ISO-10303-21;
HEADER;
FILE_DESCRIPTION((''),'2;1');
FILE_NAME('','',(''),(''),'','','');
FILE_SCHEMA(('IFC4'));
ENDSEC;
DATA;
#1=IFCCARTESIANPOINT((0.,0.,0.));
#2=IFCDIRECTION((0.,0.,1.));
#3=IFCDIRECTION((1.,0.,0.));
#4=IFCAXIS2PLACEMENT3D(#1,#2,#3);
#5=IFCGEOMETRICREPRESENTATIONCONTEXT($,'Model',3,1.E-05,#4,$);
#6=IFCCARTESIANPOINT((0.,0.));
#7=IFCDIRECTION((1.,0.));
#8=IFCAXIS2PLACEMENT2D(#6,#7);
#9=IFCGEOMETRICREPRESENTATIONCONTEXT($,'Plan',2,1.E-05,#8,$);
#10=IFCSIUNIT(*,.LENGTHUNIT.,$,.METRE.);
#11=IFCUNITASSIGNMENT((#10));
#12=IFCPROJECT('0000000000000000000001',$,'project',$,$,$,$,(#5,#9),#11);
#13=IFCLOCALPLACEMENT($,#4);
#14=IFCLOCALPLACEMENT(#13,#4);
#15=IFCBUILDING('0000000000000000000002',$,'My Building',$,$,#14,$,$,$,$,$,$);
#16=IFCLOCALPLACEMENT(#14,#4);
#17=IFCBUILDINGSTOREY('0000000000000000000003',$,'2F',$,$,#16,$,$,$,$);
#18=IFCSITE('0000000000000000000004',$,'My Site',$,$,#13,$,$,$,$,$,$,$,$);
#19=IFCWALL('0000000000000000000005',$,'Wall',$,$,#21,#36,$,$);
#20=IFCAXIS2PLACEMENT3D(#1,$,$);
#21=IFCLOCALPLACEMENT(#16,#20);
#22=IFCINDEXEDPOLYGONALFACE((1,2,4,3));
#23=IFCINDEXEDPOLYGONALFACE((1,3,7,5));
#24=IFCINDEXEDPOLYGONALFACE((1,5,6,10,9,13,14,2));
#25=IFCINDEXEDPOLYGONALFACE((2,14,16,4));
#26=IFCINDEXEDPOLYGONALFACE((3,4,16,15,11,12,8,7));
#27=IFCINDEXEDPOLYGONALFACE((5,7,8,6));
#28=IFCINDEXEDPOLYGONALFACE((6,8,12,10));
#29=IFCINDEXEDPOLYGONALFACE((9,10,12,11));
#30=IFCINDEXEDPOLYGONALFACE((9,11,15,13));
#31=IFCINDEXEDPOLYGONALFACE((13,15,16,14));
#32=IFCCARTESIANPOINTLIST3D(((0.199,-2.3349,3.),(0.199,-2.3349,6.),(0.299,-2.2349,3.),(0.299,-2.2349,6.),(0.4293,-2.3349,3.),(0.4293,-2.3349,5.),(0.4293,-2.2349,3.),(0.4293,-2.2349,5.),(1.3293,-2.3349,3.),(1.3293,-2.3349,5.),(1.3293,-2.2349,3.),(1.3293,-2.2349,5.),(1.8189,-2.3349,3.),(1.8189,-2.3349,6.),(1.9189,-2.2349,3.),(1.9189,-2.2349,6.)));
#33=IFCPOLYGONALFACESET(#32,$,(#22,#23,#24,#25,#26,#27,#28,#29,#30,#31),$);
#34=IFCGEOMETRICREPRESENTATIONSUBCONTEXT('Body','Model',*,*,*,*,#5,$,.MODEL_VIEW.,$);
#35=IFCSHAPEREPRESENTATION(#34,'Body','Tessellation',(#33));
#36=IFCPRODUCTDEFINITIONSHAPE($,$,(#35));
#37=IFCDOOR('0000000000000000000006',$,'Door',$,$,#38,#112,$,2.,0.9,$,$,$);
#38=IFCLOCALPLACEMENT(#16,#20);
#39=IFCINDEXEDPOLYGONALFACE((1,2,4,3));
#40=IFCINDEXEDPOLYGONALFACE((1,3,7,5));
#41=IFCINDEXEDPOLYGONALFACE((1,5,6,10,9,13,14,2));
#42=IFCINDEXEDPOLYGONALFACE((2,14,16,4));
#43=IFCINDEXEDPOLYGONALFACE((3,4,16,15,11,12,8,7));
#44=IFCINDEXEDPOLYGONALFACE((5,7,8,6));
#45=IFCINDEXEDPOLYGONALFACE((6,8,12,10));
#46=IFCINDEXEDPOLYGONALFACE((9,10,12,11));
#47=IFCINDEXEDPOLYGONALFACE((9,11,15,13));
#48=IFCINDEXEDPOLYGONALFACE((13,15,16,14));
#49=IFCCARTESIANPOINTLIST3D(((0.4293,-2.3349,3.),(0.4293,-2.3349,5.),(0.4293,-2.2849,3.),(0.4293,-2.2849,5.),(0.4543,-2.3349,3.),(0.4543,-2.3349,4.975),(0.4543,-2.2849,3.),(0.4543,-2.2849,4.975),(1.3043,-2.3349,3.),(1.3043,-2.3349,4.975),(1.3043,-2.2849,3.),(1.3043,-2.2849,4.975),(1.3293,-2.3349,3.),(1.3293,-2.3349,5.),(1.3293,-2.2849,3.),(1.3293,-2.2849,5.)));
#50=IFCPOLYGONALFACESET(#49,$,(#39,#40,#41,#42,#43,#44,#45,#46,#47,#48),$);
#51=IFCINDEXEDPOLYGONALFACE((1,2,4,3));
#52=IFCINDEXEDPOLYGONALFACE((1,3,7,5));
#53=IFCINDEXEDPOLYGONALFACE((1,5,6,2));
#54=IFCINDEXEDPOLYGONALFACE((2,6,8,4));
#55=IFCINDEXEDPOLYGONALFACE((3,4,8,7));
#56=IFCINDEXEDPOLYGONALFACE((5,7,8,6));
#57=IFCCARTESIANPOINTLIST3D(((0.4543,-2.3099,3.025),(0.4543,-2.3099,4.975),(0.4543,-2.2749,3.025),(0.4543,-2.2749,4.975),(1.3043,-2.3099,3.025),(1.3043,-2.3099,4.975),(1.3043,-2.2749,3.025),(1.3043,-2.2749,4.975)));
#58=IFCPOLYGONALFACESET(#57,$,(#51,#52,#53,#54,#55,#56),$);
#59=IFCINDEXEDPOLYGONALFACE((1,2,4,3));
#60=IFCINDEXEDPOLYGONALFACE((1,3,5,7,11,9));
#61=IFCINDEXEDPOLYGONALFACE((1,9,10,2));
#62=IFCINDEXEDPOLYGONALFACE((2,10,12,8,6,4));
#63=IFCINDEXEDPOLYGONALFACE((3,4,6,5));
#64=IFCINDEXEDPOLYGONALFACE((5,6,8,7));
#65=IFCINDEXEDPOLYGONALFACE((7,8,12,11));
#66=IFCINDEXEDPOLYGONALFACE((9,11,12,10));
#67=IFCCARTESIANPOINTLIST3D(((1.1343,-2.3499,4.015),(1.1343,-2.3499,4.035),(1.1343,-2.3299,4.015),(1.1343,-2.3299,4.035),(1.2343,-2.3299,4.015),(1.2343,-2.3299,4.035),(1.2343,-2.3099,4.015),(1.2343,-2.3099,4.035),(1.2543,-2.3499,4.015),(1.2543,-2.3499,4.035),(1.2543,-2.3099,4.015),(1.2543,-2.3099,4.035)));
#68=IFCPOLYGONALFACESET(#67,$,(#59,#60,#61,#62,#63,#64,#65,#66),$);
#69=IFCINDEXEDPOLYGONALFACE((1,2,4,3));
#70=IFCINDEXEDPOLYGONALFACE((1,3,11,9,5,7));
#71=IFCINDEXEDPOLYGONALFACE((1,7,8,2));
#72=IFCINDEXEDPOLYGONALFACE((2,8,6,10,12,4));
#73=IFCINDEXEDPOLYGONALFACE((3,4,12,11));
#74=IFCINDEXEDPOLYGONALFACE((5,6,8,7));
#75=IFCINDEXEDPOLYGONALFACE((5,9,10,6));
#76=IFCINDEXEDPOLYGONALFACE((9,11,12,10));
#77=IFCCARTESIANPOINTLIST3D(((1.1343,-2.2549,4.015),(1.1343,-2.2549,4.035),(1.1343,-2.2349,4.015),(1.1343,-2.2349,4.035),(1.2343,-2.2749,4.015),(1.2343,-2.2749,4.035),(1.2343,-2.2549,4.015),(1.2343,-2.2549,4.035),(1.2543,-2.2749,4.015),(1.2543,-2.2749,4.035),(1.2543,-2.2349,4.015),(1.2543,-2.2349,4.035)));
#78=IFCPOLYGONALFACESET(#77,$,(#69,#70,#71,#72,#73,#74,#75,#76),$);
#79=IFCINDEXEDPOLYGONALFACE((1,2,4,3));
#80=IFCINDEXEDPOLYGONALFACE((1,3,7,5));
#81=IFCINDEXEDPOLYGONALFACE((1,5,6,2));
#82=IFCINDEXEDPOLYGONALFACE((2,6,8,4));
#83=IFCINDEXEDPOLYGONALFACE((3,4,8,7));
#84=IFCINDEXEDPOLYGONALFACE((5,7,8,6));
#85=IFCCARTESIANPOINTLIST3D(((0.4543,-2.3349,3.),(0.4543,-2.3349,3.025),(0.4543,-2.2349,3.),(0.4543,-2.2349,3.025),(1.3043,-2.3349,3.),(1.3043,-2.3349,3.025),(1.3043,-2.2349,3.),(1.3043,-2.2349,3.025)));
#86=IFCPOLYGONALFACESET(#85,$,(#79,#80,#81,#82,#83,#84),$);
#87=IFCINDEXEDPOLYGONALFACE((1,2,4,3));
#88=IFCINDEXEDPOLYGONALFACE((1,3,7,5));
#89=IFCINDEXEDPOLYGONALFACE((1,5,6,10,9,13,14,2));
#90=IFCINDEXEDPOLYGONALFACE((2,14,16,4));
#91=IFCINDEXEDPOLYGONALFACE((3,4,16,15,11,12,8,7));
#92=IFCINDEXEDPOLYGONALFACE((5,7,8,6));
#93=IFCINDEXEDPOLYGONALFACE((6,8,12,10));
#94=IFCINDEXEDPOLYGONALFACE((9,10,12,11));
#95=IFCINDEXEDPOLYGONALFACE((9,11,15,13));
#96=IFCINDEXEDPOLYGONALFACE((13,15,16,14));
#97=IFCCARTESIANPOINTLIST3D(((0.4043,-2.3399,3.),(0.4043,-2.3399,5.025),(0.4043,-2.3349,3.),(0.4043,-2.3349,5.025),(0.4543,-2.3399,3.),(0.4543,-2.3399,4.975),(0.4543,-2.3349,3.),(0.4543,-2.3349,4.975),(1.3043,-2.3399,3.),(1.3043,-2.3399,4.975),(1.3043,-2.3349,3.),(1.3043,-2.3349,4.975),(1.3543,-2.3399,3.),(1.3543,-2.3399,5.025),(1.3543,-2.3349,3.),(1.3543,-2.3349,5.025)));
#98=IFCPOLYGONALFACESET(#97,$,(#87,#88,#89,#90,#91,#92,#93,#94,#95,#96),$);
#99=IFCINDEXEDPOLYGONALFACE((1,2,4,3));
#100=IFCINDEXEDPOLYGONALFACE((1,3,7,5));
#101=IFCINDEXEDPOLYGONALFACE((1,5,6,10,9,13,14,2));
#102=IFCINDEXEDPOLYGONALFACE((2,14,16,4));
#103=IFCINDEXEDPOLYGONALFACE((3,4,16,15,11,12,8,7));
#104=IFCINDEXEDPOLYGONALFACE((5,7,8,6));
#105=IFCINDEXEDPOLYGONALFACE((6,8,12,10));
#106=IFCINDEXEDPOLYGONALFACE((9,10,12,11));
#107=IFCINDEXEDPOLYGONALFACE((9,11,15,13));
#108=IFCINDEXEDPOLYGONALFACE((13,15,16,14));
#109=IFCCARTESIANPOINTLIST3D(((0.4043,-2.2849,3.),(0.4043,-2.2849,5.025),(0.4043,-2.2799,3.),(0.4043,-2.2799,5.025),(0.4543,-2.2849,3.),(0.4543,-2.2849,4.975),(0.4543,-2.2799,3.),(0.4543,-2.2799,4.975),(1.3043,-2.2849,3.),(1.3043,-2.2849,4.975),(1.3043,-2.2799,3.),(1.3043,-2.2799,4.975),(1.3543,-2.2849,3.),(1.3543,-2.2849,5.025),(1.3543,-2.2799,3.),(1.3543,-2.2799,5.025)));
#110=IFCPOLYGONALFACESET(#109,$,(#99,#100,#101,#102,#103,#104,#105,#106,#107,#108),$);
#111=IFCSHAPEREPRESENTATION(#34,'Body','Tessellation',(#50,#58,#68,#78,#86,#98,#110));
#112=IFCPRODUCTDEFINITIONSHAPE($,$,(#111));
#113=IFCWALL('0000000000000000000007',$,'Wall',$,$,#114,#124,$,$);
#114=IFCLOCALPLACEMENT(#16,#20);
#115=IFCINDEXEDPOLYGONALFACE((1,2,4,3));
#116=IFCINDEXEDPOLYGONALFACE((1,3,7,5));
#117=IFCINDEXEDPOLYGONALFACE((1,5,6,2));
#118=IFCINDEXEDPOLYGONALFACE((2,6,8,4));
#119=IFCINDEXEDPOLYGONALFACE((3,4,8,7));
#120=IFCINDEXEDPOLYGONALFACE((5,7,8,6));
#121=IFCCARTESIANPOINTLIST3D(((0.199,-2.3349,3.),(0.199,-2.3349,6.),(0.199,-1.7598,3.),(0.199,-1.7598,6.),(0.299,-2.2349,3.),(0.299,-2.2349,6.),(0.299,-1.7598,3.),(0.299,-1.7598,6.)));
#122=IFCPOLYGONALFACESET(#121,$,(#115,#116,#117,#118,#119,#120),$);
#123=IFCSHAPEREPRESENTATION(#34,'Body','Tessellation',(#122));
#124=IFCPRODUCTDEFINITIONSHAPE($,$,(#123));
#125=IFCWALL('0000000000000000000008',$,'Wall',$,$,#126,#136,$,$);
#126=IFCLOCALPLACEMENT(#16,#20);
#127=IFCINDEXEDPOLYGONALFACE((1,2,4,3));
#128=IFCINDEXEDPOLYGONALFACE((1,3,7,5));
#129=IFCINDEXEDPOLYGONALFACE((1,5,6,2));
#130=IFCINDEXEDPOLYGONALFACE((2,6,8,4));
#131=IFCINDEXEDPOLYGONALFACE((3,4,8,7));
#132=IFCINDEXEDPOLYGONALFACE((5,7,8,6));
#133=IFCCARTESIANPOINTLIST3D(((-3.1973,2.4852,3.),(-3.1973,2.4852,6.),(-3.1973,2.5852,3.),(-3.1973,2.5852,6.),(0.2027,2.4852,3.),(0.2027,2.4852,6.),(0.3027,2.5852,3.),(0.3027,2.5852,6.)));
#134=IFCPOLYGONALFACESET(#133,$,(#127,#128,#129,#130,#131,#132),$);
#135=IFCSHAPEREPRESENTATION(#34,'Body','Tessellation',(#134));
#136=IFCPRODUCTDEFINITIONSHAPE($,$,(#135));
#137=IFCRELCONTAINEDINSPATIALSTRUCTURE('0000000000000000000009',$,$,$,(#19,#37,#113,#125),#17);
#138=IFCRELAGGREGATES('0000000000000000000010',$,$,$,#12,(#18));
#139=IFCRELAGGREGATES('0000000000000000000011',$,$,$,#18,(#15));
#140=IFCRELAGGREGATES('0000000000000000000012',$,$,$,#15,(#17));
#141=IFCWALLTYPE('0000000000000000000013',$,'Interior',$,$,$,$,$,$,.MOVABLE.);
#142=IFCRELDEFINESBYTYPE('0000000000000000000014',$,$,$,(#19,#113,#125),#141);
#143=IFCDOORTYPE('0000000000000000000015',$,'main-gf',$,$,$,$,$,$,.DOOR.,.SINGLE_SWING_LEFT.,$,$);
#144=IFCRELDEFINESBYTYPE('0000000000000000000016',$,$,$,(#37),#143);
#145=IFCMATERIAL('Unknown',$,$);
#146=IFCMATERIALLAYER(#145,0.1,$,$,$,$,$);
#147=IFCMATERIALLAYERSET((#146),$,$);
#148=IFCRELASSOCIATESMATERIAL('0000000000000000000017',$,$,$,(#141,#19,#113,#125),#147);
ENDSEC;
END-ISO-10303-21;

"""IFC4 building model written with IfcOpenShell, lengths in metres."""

from ifc_helpers import new_model, entity, si_unit, frame, origin_with_axes, origin_2d_with_axis, place, context, subcontext, project, spatial, line, indexed_curve, outline, extrude, shape, source, transform, mapped, material, layer, layer_set, layer_usage, type_object, type_shapes, element, fill, save


model = new_model("IFC4")

# Units and contexts
model_context = context("Model", 3, precision=1e-05, world=origin_with_axes())
plan_context = context("Plan", 2, precision=1e-05, world=origin_2d_with_axis())
body_context_1 = subcontext(model_context, "Body", "Model", "MODEL_VIEW")
body_context_2 = subcontext(plan_context, "Body", "Plan", "PLAN_VIEW")
ifc_project = project(units=[si_unit("LENGTHUNIT", "METRE")], contexts=[model_context, plan_context])

# Site, building, storey
site_placement = place(None, origin_with_axes())
site = spatial("IfcSite", under=ifc_project, at=site_placement, Name="My Site")
building_placement = place(site_placement, origin_with_axes())
building = spatial("IfcBuilding", under=site, at=building_placement, Name="My Building")
storey_placement = place(building_placement, origin_with_axes())
storey = spatial("IfcBuildingStorey", under=building, at=storey_placement, Name="2F")

# Shared definitions
ifc_material = material(Name="Unknown")

# Shared definitions
ifc_layer_1 = layer(ifc_material, 0.1)
ifc_layer_set_1 = layer_set([ifc_layer_1])
wall_type = type_object("IfcWallType", Name="Interior", PredefinedType="MOVABLE", material=ifc_layer_set_1)

# Wall, opening, door
ifc_layer_usage_1 = layer_usage(ifc_layer_set_1, "AXIS2", "POSITIVE", 0.0)
wall_1_placement = place(storey_placement, frame((1.9189, -2.2349, 3.0), z_axis=(0.0, 0.0, 1.0), x_axis=(-1.0, 0.0, 0.0)))
wall_1 = element("IfcWall", 1, at=wall_1_placement, inside=storey, type_object=wall_type, material=ifc_layer_usage_1, Name="Wall", context=body_context_1, shape_type="SweptSolid", body=[
    extrude(outline(indexed_curve([(0.0, 0.0), (0.1, 0.1), (1.7199, 0.1), (1.6199, 0.0)], segments=[line(1, 2, 3, 4, 1)])), origin_with_axes(), (0.0, 0.0, 1.0), 3.0),
])
shared_shape_1 = source(origin_with_axes(), body_context_1, "Body", "SweptSolid", [
    extrude(outline(indexed_curve([(0.0, 0.0), (0.9, 0.0), (0.9, 2.0), (0.0, 2.0)], segments=[line(1, 2, 3, 4, 1)])), frame((0.0, -0.6, 0.0), z_axis=(0.0, -1.0, 0.0), x_axis=(1.0, 0.0, 0.0)), (0.0, 0.0, -1.0), 1.2),
])
opening_1_placement = place(wall_1_placement, frame((1.4896, 0.1, 0.0), z_axis=(0.0, 0.0, 1.0), x_axis=(-1.0, 0.0, 0.0)))
opening_1 = element("IfcOpeningElement", 2, at=opening_1_placement, cuts=wall_1, PredefinedType="OPENING", context=body_context_1, shape_type="MappedRepresentation", body=[
    mapped(shared_shape_1, transform((0.0, 0.0, 0.0), x_axis=(1.0, 0.0, 0.0), y_axis=(0.0, 1.0, 0.0), z_axis=(0.0, 0.0, 1.0), scale=1.0)),
])
door_type = type_object("IfcDoorType", Name="main-gf", OperationType="SINGLE_SWING_LEFT", PredefinedType="DOOR")
shared_shape_2 = source(origin_with_axes(), body_context_1, "Body", "SweptSolid", [
    extrude(outline(indexed_curve([(0.0, 0.0), (0.0, 2.0), (0.9, 2.0), (0.9, 0.0), (0.875, 0.0), (0.875, 1.975), (0.025, 1.975), (0.025, 0.0)], segments=[line(1, 2, 3, 4, 5, 6, 7, 8, 1)])), frame((0.0, 0.0, 0.0), z_axis=(0.0, -1.0, 0.0), x_axis=(1.0, 0.0, 0.0)), (0.0, 0.0, -1.0), 0.05),
    extrude(outline(indexed_curve([(0.0, 0.0), (0.85, 0.0), (0.85, 0.035), (0.0, 0.035)], segments=[line(1, 2, 3, 4, 1)])), frame((0.025, 0.025, 0.025), z_axis=(0.0, 0.0, 1.0), x_axis=(1.0, 0.0, 0.0)), (0.0, 0.0, 1.0), 1.95),
    extrude(outline(indexed_curve([(0.0, 0.0), (0.0, -0.04), (-0.12, -0.04), (-0.12, -0.02), (-0.02, -0.02), (-0.02, 0.0)], segments=[line(1, 2, 3, 4, 5, 6, 1)])), frame((0.825, 0.025, 1.015), z_axis=(0.0, 0.0, 1.0), x_axis=(1.0, 0.0, 0.0)), (0.0, 0.0, 1.0), 0.02),
    extrude(outline(indexed_curve([(0.0, 0.0), (0.0, 0.04), (-0.12, 0.04), (-0.12, 0.02), (-0.02, 0.02), (-0.02, 0.0)], segments=[line(1, 2, 3, 4, 5, 6, 1)])), frame((0.825, 0.06, 1.015), z_axis=(0.0, 0.0, 1.0), x_axis=(1.0, 0.0, 0.0)), (0.0, 0.0, 1.0), 0.02),
    extrude(outline(indexed_curve([(0.0, 0.0), (0.85, 0.0), (0.85, 0.1), (0.0, 0.1)], segments=[line(1, 2, 3, 4, 1)])), frame((0.025, 0.0, 0.0), z_axis=(0.0, 0.0, 1.0), x_axis=(1.0, 0.0, 0.0)), (0.0, 0.0, 1.0), 0.025),
    extrude(outline(indexed_curve([(0.0, 0.0), (0.0, 2.025), (0.95, 2.025), (0.95, 0.0), (0.9, 0.0), (0.9, 1.975), (0.05, 1.975), (0.05, 0.0)], segments=[line(1, 2, 3, 4, 5, 6, 7, 8, 1)])), frame((-0.025, -0.005, 0.0), z_axis=(0.0, -1.0, 0.0), x_axis=(1.0, 0.0, 0.0)), (0.0, 0.0, -1.0), 0.005),
    extrude(outline(indexed_curve([(0.0, 0.0), (0.0, 2.025), (0.95, 2.025), (0.95, 0.0), (0.9, 0.0), (0.9, 1.975), (0.05, 1.975), (0.05, 0.0)], segments=[line(1, 2, 3, 4, 5, 6, 7, 8, 1)])), frame((-0.025, 0.05, 0.0), z_axis=(0.0, -1.0, 0.0), x_axis=(1.0, 0.0, 0.0)), (0.0, 0.0, -1.0), 0.005),
])
shared_shape_3 = source(origin_with_axes(), body_context_2, "Body", "Curve2D", [
    entity("IfcIndexedPolyCurve", entity("IfcCartesianPointList2D", [[0.0, 0.0], [0.025, 0.0], [0.025, 0.05], [0.0, 0.05]]), [entity("IfcLineIndex", [1, 2, 3, 4, 1])]),
    entity("IfcIndexedPolyCurve", entity("IfcCartesianPointList2D", [[0.9, 0.0], [0.875, 0.0], [0.875, 0.05], [0.9, 0.05]]), [entity("IfcLineIndex", [1, 2, 3, 4, 1])]),
    entity("IfcIndexedPolyCurve", entity("IfcCartesianPointList2D", [[0.025, 0.05], [0.025, -0.8], [0.06, -0.8]])),
    entity("IfcTrimmedCurve", entity("IfcEllipse", entity("IfcAxis2Placement2D", entity("IfcCartesianPoint", [0.06, 0.05]), entity("IfcDirection", [1.0, 0.0])), 0.815, 0.85), [entity("IfcCartesianPoint", [0.06, -0.8])], [entity("IfcCartesianPoint", [0.06, 0.9])], True, "CARTESIAN"),
    entity("IfcIndexedPolyCurve", entity("IfcCartesianPointList2D", [[0.025, 0.05], [0.06, 0.05], [0.06, 0.9], [0.025, 0.9]]), [entity("IfcLineIndex", [1, 2, 3, 4, 1])]),
])
type_shapes(door_type, [shared_shape_2, shared_shape_3])
door_1_placement = place(opening_1_placement, frame((0.0, 0.0, 0.0), z_axis=(0.0, 0.0, 1.0), x_axis=(1.0, 0.0, 0.0)))
door_1 = element("IfcDoor", 3, at=door_1_placement, inside=storey, type_object=door_type, Name="Door", OverallHeight=2.0, OverallWidth=0.9, shapes=[
    shape(body_context_1, "Body", "MappedRepresentation", [mapped(shared_shape_2, transform((0.0, 0.0, 0.0), x_axis=(1.0, 0.0, 0.0), y_axis=(0.0, 1.0, 0.0), z_axis=(0.0, 0.0, 1.0), scale=1.0))]),
    shape(body_context_2, "Body", "MappedRepresentation", [mapped(shared_shape_3, transform((0.0, 0.0, 0.0), x_axis=(1.0, 0.0, 0.0), y_axis=(0.0, 1.0, 0.0), z_axis=(0.0, 0.0, 1.0), scale=1.0))]),
])
fill(opening_1, door_1)

# Walls
ifc_layer_usage_2 = layer_usage(ifc_layer_set_1, "AXIS2", "POSITIVE", 0.0)
wall_2_placement = place(storey_placement, frame((0.199, -1.7598, 3.0), z_axis=(0.0, 0.0, 1.0), x_axis=(0.0, -1.0, 0.0)))
element("IfcWall", 4, at=wall_2_placement, inside=storey, type_object=wall_type, material=ifc_layer_usage_2, Name="Wall", context=body_context_1, shape_type="SweptSolid", body=[
    extrude(outline(indexed_curve([(0.0, 0.0), (0.0, 0.1), (0.4751, 0.1), (0.5751, 0.0)], segments=[line(1, 2, 3, 4, 1)])), origin_with_axes(), (0.0, 0.0, 1.0), 3.0),
])
ifc_layer_usage_3 = layer_usage(ifc_layer_set_1, "AXIS2", "POSITIVE", 0.0)
wall_3_placement = place(storey_placement, frame((-3.1973, 2.4852, 3.0), z_axis=(0.0, 0.0, 1.0), x_axis=(1.0, 0.0, 0.0)))
element("IfcWall", 5, at=wall_3_placement, inside=storey, type_object=wall_type, material=ifc_layer_usage_3, Name="Wall", context=body_context_1, shape_type="SweptSolid", body=[
    extrude(outline(indexed_curve([(0.0, 0.0), (0.0, 0.1), (3.5, 0.1), (3.4, 0.0)], segments=[line(1, 2, 3, 4, 1)])), origin_with_axes(), (0.0, 0.0, 1.0), 3.0),
])

save(model, "model.ifc")
